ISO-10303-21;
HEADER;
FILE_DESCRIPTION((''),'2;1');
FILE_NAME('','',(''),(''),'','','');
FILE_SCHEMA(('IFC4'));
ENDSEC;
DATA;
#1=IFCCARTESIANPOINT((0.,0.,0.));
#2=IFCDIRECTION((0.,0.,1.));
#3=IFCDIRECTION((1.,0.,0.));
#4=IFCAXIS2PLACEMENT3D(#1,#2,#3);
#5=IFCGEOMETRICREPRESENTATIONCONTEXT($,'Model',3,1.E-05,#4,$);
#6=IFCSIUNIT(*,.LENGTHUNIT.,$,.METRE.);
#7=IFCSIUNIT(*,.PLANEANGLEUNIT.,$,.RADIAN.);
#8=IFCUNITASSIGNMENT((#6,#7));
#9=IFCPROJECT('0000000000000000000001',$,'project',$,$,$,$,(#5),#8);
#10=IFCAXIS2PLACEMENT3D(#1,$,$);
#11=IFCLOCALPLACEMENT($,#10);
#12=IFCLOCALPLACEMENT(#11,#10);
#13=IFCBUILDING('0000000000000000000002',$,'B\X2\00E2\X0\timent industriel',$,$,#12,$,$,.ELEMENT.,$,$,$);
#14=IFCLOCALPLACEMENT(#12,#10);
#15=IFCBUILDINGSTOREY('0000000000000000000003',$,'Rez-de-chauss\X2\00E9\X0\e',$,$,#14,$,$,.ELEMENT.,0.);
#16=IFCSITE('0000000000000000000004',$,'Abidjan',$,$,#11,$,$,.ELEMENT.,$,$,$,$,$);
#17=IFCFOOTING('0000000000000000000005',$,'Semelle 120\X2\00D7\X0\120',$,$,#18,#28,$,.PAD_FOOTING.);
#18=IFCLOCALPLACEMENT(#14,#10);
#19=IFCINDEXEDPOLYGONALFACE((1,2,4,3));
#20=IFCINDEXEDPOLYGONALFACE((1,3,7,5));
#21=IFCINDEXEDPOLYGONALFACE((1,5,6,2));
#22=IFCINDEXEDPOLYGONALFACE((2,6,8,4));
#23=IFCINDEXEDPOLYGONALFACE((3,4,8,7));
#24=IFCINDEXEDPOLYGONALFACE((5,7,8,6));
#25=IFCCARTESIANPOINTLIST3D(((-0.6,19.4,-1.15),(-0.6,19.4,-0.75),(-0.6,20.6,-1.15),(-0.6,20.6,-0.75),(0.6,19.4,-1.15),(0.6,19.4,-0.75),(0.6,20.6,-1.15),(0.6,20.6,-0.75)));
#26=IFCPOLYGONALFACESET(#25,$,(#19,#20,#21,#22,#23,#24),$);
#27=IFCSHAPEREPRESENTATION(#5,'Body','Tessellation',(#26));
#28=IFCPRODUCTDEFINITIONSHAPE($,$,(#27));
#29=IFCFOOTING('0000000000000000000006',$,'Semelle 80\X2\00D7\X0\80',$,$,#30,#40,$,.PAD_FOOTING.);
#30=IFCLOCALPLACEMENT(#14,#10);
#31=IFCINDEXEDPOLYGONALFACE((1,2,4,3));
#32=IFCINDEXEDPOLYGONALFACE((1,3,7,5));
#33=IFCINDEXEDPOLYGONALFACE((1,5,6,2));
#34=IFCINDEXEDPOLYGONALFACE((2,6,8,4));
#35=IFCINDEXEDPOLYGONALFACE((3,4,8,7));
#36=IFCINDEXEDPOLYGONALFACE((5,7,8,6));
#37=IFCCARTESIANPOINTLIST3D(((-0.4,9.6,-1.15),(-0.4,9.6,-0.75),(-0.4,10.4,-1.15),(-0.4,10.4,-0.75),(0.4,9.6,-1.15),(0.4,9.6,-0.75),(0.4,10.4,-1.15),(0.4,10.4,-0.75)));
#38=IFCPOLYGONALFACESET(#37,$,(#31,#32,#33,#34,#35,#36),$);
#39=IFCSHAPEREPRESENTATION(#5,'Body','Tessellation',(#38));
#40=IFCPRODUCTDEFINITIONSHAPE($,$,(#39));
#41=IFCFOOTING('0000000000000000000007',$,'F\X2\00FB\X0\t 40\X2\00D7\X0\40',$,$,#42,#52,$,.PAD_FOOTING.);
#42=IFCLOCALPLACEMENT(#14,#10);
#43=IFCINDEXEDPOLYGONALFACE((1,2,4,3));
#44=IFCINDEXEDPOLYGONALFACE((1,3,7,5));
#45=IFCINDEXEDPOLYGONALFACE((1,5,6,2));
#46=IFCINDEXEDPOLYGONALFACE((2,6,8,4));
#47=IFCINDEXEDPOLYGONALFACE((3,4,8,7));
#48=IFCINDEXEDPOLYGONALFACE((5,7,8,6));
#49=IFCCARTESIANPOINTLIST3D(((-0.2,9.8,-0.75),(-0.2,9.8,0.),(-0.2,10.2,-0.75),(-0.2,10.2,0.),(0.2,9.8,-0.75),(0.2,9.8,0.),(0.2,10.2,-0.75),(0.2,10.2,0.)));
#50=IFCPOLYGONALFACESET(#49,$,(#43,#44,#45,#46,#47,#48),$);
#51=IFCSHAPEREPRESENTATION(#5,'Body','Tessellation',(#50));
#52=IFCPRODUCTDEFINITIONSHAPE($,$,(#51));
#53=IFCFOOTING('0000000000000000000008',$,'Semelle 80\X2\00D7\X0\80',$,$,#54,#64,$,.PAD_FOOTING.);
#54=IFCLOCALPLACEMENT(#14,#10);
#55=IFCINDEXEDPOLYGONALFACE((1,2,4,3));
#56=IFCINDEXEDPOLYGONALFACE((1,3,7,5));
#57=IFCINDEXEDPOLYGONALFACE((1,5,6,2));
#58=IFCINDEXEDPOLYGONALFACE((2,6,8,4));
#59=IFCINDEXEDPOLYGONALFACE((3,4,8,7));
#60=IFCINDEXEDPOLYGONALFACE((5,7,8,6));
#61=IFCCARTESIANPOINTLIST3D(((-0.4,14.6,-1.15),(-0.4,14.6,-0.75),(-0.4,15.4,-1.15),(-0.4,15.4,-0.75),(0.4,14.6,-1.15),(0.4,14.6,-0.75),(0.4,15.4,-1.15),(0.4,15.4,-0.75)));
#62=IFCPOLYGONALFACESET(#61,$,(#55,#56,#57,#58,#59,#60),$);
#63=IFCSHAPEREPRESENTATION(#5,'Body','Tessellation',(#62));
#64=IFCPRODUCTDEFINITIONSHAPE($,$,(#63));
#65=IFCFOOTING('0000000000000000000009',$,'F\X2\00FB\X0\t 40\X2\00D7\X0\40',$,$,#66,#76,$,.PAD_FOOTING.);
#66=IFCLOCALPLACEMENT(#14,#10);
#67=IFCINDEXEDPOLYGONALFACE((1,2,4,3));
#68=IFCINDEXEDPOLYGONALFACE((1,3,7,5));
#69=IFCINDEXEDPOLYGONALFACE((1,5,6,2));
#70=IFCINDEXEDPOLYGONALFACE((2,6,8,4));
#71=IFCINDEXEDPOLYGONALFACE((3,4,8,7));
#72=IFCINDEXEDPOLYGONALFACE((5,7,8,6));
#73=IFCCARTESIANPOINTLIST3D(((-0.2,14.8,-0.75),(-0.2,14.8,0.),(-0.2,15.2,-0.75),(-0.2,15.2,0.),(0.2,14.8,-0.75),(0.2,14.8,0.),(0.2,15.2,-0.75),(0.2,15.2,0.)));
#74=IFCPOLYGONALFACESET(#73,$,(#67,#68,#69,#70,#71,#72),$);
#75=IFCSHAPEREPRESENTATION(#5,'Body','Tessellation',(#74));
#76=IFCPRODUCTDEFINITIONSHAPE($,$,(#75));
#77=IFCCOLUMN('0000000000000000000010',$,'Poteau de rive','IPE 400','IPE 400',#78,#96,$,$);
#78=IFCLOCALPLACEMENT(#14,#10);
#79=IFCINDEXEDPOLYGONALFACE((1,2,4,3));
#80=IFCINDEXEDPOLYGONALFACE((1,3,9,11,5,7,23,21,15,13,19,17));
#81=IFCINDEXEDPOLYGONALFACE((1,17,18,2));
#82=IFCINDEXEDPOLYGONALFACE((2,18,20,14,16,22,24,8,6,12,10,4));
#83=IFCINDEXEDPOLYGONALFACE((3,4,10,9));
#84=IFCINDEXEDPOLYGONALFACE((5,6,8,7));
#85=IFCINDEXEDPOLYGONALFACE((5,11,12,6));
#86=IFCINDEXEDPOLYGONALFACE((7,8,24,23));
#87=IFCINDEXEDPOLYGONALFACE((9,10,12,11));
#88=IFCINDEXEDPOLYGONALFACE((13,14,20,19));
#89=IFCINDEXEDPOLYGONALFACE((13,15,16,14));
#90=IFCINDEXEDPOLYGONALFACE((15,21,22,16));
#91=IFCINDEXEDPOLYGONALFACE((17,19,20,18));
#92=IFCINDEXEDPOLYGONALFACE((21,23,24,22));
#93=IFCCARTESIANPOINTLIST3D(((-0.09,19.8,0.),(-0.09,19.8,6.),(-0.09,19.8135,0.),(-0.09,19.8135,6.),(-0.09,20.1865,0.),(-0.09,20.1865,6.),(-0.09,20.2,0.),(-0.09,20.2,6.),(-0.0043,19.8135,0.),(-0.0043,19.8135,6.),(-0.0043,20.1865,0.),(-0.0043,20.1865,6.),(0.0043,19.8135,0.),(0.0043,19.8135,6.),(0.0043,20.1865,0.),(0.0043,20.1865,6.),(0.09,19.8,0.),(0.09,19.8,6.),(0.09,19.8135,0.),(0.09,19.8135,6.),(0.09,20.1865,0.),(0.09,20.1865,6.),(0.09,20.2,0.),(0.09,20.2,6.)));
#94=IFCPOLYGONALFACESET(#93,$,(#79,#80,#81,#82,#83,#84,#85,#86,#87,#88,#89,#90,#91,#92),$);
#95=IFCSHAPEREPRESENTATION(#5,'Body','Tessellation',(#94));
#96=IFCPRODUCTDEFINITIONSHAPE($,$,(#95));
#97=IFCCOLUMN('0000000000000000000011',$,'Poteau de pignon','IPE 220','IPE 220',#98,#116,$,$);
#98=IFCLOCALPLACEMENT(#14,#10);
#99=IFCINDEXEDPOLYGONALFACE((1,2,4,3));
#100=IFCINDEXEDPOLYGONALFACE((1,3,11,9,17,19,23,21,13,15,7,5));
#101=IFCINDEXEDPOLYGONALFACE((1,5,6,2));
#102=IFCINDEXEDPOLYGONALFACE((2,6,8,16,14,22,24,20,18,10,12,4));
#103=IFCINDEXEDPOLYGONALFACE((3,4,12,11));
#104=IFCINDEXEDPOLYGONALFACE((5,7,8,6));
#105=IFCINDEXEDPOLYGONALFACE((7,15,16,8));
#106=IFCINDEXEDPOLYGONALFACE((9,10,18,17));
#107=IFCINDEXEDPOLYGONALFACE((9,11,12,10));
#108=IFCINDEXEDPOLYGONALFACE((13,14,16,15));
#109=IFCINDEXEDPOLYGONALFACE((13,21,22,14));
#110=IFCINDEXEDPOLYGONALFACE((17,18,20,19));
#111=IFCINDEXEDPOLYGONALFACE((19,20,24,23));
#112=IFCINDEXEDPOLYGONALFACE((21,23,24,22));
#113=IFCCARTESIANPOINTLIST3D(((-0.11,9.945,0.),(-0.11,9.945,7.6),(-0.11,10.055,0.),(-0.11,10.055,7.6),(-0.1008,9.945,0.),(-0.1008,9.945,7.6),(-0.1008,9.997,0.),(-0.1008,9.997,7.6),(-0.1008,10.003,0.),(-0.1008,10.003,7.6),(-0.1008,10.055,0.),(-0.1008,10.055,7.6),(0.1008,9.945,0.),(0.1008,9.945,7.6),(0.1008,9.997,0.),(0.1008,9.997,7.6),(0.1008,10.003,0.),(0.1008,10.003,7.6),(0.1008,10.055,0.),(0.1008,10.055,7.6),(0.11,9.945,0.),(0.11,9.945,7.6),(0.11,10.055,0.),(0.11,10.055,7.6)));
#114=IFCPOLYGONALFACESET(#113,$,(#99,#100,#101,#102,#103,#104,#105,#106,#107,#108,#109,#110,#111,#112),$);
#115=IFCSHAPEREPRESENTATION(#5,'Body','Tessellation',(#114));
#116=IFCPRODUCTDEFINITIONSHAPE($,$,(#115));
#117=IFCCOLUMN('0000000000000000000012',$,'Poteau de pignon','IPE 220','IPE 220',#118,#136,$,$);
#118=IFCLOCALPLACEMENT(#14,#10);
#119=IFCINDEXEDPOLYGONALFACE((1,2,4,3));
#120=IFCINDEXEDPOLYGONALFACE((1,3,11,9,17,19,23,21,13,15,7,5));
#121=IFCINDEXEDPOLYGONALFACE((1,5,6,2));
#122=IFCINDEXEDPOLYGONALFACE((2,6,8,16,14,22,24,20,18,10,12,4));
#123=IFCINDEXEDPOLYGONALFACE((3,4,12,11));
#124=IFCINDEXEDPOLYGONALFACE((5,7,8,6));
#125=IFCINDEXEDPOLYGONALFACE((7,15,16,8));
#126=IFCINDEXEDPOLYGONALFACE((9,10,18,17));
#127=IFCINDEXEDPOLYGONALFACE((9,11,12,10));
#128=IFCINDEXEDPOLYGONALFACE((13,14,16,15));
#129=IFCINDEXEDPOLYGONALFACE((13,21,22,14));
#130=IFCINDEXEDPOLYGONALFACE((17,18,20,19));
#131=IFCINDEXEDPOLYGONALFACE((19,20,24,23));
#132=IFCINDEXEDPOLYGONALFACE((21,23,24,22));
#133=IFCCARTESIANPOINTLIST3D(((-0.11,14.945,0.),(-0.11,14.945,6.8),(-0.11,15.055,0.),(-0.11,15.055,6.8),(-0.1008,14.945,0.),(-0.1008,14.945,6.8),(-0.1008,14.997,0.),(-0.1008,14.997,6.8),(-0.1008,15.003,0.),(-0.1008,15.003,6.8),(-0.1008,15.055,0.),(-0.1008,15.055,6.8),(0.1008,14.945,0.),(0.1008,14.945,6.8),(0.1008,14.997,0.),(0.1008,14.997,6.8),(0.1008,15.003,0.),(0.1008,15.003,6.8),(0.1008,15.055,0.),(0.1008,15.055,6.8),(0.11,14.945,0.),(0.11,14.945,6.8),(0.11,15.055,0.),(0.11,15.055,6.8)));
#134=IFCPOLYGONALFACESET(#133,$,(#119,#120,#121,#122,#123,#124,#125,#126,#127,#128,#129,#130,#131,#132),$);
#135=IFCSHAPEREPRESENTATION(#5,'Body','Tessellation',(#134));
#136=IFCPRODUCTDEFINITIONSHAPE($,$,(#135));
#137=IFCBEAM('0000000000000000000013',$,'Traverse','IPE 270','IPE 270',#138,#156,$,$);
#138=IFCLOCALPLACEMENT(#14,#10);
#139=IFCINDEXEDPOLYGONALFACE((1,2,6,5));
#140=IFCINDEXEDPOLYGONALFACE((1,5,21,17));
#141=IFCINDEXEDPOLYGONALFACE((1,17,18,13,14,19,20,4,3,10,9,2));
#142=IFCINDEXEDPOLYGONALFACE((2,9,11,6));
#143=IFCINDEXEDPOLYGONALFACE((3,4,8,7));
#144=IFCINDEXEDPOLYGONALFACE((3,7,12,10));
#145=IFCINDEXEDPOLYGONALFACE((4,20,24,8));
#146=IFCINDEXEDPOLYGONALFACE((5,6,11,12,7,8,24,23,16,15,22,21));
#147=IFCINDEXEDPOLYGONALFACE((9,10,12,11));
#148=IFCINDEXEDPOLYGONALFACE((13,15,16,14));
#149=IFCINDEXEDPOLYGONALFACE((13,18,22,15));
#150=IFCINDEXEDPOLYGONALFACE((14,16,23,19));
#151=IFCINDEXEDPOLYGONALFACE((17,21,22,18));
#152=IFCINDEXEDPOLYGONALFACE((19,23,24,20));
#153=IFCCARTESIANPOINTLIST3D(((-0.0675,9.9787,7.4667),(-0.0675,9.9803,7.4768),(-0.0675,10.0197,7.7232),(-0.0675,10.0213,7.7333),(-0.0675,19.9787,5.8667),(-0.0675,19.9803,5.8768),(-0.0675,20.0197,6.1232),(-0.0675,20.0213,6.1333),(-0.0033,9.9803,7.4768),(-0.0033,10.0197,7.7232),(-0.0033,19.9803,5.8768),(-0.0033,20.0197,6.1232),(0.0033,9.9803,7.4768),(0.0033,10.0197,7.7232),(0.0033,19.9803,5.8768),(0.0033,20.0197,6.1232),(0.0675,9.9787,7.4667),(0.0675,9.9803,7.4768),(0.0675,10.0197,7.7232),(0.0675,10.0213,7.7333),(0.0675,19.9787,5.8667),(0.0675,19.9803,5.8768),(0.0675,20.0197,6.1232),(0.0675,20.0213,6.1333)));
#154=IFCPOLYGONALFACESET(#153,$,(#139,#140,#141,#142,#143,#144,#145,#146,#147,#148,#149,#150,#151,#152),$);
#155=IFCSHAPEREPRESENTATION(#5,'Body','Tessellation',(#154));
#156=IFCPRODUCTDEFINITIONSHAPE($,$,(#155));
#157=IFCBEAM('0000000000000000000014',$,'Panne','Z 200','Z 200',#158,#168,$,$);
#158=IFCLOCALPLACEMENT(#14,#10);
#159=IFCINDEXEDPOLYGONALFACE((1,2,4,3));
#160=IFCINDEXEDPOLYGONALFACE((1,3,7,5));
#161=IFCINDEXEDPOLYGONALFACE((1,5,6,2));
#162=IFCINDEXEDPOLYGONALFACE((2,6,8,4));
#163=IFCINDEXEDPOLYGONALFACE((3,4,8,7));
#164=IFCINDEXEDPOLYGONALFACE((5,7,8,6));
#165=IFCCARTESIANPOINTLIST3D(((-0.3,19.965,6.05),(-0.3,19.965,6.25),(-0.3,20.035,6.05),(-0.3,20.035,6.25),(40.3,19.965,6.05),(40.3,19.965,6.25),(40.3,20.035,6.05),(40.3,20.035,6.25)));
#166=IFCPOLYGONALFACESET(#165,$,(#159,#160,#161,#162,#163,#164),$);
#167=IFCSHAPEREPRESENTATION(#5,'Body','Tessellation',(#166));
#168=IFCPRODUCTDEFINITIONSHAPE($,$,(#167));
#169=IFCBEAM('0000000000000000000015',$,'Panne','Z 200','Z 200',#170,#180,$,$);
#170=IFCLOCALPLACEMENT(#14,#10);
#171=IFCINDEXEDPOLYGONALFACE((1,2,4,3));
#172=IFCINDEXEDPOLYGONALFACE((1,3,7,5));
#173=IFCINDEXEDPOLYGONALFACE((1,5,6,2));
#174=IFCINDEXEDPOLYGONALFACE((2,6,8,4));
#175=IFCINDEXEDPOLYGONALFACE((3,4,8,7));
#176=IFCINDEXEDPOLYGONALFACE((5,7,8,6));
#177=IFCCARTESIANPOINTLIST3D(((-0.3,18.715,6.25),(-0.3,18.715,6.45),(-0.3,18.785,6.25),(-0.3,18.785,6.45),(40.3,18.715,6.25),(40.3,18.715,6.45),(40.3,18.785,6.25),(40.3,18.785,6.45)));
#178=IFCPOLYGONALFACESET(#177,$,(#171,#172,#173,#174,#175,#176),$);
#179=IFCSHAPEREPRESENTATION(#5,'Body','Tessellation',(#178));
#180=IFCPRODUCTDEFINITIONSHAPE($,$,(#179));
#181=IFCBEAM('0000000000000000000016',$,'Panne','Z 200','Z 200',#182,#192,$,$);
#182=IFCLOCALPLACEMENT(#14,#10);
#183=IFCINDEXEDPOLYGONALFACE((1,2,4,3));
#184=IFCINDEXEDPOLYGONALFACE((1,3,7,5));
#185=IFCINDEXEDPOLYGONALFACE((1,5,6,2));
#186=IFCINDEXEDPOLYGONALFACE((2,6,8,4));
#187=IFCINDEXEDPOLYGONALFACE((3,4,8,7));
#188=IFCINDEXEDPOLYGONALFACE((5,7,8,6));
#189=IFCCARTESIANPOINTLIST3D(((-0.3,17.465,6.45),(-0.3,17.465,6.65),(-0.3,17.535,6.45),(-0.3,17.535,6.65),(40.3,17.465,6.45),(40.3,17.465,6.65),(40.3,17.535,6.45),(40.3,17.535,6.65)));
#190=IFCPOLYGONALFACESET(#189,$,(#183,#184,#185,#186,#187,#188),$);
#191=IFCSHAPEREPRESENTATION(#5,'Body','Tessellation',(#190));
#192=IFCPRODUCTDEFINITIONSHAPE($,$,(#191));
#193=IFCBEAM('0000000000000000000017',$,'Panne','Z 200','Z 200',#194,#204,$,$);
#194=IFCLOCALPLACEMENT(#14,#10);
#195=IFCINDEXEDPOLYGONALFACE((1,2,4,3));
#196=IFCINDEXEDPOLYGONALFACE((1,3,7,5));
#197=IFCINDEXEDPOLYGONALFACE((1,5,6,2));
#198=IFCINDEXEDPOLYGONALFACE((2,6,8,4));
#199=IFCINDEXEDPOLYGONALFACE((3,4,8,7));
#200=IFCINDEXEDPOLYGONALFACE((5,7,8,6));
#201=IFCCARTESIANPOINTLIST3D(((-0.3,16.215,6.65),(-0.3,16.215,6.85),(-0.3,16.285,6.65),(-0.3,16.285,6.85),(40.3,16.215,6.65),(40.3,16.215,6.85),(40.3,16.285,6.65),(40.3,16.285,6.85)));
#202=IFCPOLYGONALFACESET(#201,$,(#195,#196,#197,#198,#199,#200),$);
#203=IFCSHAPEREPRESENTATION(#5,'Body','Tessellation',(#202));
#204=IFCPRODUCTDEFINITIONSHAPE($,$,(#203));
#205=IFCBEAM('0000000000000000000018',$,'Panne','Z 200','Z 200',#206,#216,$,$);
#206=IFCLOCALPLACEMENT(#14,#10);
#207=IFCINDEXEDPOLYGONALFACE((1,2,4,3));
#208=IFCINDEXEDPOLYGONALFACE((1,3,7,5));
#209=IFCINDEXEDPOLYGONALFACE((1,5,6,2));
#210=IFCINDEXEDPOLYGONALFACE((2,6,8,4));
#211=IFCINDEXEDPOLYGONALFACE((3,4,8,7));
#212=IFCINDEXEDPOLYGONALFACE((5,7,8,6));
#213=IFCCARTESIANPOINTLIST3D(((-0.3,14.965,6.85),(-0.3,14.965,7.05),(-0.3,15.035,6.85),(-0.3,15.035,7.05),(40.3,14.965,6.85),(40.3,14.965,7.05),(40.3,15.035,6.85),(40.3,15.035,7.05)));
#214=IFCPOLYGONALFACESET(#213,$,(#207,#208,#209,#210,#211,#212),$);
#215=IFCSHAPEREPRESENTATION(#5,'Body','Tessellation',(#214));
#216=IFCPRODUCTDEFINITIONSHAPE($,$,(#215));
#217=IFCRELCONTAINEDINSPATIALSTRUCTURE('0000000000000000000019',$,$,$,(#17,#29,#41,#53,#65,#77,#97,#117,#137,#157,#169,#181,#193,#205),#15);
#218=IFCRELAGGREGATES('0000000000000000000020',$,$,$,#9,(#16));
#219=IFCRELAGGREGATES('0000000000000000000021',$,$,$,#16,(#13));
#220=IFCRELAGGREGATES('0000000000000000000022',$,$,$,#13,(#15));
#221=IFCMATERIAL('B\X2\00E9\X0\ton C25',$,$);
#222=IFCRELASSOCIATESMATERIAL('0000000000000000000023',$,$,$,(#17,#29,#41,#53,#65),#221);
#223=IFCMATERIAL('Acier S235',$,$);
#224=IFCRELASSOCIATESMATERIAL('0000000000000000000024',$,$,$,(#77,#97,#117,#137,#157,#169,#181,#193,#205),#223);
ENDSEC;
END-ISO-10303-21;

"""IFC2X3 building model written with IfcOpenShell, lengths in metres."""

from ifc_helpers import new_model, si_unit, frame, origin, origin_with_axes, origin_2d, place, context, project, spatial, rectangle, i_section, extrude, material, element, save


model = new_model("IFC2X3")

# Units and contexts
model_context = context("Model", 3, precision=1e-05, world=origin_with_axes())
ifc_project = project(units=[si_unit("LENGTHUNIT", "METRE"), si_unit("PLANEANGLEUNIT", "RADIAN")], contexts=[model_context])

# Site, building, storey
site_placement = place(None, origin())
site = spatial("IfcSite", under=ifc_project, at=site_placement, Name="Abidjan", CompositionType="ELEMENT")
building_placement = place(site_placement, origin())
building = spatial("IfcBuilding", under=site, at=building_placement, Name="Bâtiment industriel", CompositionType="ELEMENT")
storey_placement = place(building_placement, origin())
storey = spatial("IfcBuildingStorey", under=building, at=storey_placement, Name="Rez-de-chaussée", CompositionType="ELEMENT", Elevation=0.0)

# Footings
ifc_material_1 = material(Name="Béton C25")
footing_1_placement = place(storey_placement, frame((0.0, 20.0, -1.15), z_axis=(0.0, 0.0, 1.0), x_axis=(1.0, 0.0, 0.0)))
element("IfcFooting", 1, at=footing_1_placement, inside=storey, material=ifc_material_1, Name="Semelle 120×120", PredefinedType="PAD_FOOTING", context=model_context, shape_type="SweptSolid", body=[
    extrude(rectangle(XDim=1.2, YDim=1.2, at=origin_2d()), origin(), (0.0, 0.0, 1.0), 0.4),
])
footing_2_placement = place(storey_placement, frame((0.0, 10.0, -1.15), z_axis=(0.0, 0.0, 1.0), x_axis=(1.0, 0.0, 0.0)))
element("IfcFooting", 2, at=footing_2_placement, inside=storey, material=ifc_material_1, Name="Semelle 80×80", PredefinedType="PAD_FOOTING", context=model_context, shape_type="SweptSolid", body=[
    extrude(rectangle(XDim=0.8, YDim=0.8, at=origin_2d()), origin(), (0.0, 0.0, 1.0), 0.4),
])
footing_3_placement = place(storey_placement, frame((0.0, 10.0, -0.75), z_axis=(0.0, 0.0, 1.0), x_axis=(1.0, 0.0, 0.0)))
element("IfcFooting", 3, at=footing_3_placement, inside=storey, material=ifc_material_1, Name="Fût 40×40", PredefinedType="PAD_FOOTING", context=model_context, shape_type="SweptSolid", body=[
    extrude(rectangle(XDim=0.4, YDim=0.4, at=origin_2d()), origin(), (0.0, 0.0, 1.0), 0.75),
])
footing_4_placement = place(storey_placement, frame((0.0, 15.0, -1.15), z_axis=(0.0, 0.0, 1.0), x_axis=(1.0, 0.0, 0.0)))
element("IfcFooting", 4, at=footing_4_placement, inside=storey, material=ifc_material_1, Name="Semelle 80×80", PredefinedType="PAD_FOOTING", context=model_context, shape_type="SweptSolid", body=[
    extrude(rectangle(XDim=0.8, YDim=0.8, at=origin_2d()), origin(), (0.0, 0.0, 1.0), 0.4),
])
footing_5_placement = place(storey_placement, frame((0.0, 15.0, -0.75), z_axis=(0.0, 0.0, 1.0), x_axis=(1.0, 0.0, 0.0)))
element("IfcFooting", 5, at=footing_5_placement, inside=storey, material=ifc_material_1, Name="Fût 40×40", PredefinedType="PAD_FOOTING", context=model_context, shape_type="SweptSolid", body=[
    extrude(rectangle(XDim=0.4, YDim=0.4, at=origin_2d()), origin(), (0.0, 0.0, 1.0), 0.75),
])

# Columns
ifc_material_2 = material(Name="Acier S235")
column_1_placement = place(storey_placement, frame((0.0, 20.0, 0.0), z_axis=(0.0, 0.0, 1.0), x_axis=(1.0, 0.0, 0.0)))
element("IfcColumn", 6, at=column_1_placement, inside=storey, material=ifc_material_2, Name="Poteau de rive", Description="IPE 400", ObjectType="IPE 400", context=model_context, shape_type="SweptSolid", body=[
    extrude(i_section(OverallWidth=0.18, OverallDepth=0.4, WebThickness=0.0086, FlangeThickness=0.0135, at=origin_2d()), origin(), (0.0, 0.0, 1.0), 6.0),
])
column_2_placement = place(storey_placement, frame((0.0, 10.0, 0.0), z_axis=(0.0, 0.0, 1.0), x_axis=(0.0, 1.0, 0.0)))
element("IfcColumn", 7, at=column_2_placement, inside=storey, material=ifc_material_2, Name="Poteau de pignon", Description="IPE 220", ObjectType="IPE 220", context=model_context, shape_type="SweptSolid", body=[
    extrude(i_section(OverallWidth=0.11, OverallDepth=0.22, WebThickness=0.0059, FlangeThickness=0.0092, at=origin_2d()), origin(), (0.0, 0.0, 1.0), 7.6),
])
column_3_placement = place(storey_placement, frame((0.0, 15.0, 0.0), z_axis=(0.0, 0.0, 1.0), x_axis=(0.0, 1.0, 0.0)))
element("IfcColumn", 8, at=column_3_placement, inside=storey, material=ifc_material_2, Name="Poteau de pignon", Description="IPE 220", ObjectType="IPE 220", context=model_context, shape_type="SweptSolid", body=[
    extrude(i_section(OverallWidth=0.11, OverallDepth=0.22, WebThickness=0.0059, FlangeThickness=0.0092, at=origin_2d()), origin(), (0.0, 0.0, 1.0), 6.8),
])

# Beams
beam_placement = place(storey_placement, frame((0.0, 10.0, 7.6), z_axis=(0.0, 0.98744, -0.15799), x_axis=(1.0, 0.0, 0.0)))
element("IfcBeam", 9, at=beam_placement, inside=storey, material=ifc_material_2, Name="Traverse", Description="IPE 270", ObjectType="IPE 270", context=model_context, shape_type="SweptSolid", body=[
    extrude(i_section(OverallWidth=0.135, OverallDepth=0.27, WebThickness=0.0066, FlangeThickness=0.0102, at=origin_2d()), origin(), (0.0, 0.0, 1.0), 10.1272),
])
for number, where, z_axis, x_axis, name in (
    (10, (-0.3, 20.0, 6.15), (1.0, 0.0, 0.0), (0.0, 1.0, 0.0), "Panne"),
    (11, (-0.3, 18.75, 6.35), (1.0, 0.0, 0.0), (0.0, 1.0, 0.0), "Panne"),
    (12, (-0.3, 17.5, 6.55), (1.0, 0.0, 0.0), (0.0, 1.0, 0.0), "Panne"),
    (13, (-0.3, 16.25, 6.75), (1.0, 0.0, 0.0), (0.0, 1.0, 0.0), "Panne"),
    (14, (-0.3, 15.0, 6.95), (1.0, 0.0, 0.0), (0.0, 1.0, 0.0), "Panne"),
):
    element("IfcBeam", number, at=place(storey_placement, frame(where, z_axis=z_axis, x_axis=x_axis)), inside=storey, material=ifc_material_2, Name=name, Description="Z 200", ObjectType="Z 200", context=model_context, shape_type="SweptSolid", body=[
        extrude(rectangle(XDim=0.07, YDim=0.2, at=origin_2d()), origin(), (0.0, 0.0, 1.0), 40.6),
    ])

save(model, "model.ifc")
